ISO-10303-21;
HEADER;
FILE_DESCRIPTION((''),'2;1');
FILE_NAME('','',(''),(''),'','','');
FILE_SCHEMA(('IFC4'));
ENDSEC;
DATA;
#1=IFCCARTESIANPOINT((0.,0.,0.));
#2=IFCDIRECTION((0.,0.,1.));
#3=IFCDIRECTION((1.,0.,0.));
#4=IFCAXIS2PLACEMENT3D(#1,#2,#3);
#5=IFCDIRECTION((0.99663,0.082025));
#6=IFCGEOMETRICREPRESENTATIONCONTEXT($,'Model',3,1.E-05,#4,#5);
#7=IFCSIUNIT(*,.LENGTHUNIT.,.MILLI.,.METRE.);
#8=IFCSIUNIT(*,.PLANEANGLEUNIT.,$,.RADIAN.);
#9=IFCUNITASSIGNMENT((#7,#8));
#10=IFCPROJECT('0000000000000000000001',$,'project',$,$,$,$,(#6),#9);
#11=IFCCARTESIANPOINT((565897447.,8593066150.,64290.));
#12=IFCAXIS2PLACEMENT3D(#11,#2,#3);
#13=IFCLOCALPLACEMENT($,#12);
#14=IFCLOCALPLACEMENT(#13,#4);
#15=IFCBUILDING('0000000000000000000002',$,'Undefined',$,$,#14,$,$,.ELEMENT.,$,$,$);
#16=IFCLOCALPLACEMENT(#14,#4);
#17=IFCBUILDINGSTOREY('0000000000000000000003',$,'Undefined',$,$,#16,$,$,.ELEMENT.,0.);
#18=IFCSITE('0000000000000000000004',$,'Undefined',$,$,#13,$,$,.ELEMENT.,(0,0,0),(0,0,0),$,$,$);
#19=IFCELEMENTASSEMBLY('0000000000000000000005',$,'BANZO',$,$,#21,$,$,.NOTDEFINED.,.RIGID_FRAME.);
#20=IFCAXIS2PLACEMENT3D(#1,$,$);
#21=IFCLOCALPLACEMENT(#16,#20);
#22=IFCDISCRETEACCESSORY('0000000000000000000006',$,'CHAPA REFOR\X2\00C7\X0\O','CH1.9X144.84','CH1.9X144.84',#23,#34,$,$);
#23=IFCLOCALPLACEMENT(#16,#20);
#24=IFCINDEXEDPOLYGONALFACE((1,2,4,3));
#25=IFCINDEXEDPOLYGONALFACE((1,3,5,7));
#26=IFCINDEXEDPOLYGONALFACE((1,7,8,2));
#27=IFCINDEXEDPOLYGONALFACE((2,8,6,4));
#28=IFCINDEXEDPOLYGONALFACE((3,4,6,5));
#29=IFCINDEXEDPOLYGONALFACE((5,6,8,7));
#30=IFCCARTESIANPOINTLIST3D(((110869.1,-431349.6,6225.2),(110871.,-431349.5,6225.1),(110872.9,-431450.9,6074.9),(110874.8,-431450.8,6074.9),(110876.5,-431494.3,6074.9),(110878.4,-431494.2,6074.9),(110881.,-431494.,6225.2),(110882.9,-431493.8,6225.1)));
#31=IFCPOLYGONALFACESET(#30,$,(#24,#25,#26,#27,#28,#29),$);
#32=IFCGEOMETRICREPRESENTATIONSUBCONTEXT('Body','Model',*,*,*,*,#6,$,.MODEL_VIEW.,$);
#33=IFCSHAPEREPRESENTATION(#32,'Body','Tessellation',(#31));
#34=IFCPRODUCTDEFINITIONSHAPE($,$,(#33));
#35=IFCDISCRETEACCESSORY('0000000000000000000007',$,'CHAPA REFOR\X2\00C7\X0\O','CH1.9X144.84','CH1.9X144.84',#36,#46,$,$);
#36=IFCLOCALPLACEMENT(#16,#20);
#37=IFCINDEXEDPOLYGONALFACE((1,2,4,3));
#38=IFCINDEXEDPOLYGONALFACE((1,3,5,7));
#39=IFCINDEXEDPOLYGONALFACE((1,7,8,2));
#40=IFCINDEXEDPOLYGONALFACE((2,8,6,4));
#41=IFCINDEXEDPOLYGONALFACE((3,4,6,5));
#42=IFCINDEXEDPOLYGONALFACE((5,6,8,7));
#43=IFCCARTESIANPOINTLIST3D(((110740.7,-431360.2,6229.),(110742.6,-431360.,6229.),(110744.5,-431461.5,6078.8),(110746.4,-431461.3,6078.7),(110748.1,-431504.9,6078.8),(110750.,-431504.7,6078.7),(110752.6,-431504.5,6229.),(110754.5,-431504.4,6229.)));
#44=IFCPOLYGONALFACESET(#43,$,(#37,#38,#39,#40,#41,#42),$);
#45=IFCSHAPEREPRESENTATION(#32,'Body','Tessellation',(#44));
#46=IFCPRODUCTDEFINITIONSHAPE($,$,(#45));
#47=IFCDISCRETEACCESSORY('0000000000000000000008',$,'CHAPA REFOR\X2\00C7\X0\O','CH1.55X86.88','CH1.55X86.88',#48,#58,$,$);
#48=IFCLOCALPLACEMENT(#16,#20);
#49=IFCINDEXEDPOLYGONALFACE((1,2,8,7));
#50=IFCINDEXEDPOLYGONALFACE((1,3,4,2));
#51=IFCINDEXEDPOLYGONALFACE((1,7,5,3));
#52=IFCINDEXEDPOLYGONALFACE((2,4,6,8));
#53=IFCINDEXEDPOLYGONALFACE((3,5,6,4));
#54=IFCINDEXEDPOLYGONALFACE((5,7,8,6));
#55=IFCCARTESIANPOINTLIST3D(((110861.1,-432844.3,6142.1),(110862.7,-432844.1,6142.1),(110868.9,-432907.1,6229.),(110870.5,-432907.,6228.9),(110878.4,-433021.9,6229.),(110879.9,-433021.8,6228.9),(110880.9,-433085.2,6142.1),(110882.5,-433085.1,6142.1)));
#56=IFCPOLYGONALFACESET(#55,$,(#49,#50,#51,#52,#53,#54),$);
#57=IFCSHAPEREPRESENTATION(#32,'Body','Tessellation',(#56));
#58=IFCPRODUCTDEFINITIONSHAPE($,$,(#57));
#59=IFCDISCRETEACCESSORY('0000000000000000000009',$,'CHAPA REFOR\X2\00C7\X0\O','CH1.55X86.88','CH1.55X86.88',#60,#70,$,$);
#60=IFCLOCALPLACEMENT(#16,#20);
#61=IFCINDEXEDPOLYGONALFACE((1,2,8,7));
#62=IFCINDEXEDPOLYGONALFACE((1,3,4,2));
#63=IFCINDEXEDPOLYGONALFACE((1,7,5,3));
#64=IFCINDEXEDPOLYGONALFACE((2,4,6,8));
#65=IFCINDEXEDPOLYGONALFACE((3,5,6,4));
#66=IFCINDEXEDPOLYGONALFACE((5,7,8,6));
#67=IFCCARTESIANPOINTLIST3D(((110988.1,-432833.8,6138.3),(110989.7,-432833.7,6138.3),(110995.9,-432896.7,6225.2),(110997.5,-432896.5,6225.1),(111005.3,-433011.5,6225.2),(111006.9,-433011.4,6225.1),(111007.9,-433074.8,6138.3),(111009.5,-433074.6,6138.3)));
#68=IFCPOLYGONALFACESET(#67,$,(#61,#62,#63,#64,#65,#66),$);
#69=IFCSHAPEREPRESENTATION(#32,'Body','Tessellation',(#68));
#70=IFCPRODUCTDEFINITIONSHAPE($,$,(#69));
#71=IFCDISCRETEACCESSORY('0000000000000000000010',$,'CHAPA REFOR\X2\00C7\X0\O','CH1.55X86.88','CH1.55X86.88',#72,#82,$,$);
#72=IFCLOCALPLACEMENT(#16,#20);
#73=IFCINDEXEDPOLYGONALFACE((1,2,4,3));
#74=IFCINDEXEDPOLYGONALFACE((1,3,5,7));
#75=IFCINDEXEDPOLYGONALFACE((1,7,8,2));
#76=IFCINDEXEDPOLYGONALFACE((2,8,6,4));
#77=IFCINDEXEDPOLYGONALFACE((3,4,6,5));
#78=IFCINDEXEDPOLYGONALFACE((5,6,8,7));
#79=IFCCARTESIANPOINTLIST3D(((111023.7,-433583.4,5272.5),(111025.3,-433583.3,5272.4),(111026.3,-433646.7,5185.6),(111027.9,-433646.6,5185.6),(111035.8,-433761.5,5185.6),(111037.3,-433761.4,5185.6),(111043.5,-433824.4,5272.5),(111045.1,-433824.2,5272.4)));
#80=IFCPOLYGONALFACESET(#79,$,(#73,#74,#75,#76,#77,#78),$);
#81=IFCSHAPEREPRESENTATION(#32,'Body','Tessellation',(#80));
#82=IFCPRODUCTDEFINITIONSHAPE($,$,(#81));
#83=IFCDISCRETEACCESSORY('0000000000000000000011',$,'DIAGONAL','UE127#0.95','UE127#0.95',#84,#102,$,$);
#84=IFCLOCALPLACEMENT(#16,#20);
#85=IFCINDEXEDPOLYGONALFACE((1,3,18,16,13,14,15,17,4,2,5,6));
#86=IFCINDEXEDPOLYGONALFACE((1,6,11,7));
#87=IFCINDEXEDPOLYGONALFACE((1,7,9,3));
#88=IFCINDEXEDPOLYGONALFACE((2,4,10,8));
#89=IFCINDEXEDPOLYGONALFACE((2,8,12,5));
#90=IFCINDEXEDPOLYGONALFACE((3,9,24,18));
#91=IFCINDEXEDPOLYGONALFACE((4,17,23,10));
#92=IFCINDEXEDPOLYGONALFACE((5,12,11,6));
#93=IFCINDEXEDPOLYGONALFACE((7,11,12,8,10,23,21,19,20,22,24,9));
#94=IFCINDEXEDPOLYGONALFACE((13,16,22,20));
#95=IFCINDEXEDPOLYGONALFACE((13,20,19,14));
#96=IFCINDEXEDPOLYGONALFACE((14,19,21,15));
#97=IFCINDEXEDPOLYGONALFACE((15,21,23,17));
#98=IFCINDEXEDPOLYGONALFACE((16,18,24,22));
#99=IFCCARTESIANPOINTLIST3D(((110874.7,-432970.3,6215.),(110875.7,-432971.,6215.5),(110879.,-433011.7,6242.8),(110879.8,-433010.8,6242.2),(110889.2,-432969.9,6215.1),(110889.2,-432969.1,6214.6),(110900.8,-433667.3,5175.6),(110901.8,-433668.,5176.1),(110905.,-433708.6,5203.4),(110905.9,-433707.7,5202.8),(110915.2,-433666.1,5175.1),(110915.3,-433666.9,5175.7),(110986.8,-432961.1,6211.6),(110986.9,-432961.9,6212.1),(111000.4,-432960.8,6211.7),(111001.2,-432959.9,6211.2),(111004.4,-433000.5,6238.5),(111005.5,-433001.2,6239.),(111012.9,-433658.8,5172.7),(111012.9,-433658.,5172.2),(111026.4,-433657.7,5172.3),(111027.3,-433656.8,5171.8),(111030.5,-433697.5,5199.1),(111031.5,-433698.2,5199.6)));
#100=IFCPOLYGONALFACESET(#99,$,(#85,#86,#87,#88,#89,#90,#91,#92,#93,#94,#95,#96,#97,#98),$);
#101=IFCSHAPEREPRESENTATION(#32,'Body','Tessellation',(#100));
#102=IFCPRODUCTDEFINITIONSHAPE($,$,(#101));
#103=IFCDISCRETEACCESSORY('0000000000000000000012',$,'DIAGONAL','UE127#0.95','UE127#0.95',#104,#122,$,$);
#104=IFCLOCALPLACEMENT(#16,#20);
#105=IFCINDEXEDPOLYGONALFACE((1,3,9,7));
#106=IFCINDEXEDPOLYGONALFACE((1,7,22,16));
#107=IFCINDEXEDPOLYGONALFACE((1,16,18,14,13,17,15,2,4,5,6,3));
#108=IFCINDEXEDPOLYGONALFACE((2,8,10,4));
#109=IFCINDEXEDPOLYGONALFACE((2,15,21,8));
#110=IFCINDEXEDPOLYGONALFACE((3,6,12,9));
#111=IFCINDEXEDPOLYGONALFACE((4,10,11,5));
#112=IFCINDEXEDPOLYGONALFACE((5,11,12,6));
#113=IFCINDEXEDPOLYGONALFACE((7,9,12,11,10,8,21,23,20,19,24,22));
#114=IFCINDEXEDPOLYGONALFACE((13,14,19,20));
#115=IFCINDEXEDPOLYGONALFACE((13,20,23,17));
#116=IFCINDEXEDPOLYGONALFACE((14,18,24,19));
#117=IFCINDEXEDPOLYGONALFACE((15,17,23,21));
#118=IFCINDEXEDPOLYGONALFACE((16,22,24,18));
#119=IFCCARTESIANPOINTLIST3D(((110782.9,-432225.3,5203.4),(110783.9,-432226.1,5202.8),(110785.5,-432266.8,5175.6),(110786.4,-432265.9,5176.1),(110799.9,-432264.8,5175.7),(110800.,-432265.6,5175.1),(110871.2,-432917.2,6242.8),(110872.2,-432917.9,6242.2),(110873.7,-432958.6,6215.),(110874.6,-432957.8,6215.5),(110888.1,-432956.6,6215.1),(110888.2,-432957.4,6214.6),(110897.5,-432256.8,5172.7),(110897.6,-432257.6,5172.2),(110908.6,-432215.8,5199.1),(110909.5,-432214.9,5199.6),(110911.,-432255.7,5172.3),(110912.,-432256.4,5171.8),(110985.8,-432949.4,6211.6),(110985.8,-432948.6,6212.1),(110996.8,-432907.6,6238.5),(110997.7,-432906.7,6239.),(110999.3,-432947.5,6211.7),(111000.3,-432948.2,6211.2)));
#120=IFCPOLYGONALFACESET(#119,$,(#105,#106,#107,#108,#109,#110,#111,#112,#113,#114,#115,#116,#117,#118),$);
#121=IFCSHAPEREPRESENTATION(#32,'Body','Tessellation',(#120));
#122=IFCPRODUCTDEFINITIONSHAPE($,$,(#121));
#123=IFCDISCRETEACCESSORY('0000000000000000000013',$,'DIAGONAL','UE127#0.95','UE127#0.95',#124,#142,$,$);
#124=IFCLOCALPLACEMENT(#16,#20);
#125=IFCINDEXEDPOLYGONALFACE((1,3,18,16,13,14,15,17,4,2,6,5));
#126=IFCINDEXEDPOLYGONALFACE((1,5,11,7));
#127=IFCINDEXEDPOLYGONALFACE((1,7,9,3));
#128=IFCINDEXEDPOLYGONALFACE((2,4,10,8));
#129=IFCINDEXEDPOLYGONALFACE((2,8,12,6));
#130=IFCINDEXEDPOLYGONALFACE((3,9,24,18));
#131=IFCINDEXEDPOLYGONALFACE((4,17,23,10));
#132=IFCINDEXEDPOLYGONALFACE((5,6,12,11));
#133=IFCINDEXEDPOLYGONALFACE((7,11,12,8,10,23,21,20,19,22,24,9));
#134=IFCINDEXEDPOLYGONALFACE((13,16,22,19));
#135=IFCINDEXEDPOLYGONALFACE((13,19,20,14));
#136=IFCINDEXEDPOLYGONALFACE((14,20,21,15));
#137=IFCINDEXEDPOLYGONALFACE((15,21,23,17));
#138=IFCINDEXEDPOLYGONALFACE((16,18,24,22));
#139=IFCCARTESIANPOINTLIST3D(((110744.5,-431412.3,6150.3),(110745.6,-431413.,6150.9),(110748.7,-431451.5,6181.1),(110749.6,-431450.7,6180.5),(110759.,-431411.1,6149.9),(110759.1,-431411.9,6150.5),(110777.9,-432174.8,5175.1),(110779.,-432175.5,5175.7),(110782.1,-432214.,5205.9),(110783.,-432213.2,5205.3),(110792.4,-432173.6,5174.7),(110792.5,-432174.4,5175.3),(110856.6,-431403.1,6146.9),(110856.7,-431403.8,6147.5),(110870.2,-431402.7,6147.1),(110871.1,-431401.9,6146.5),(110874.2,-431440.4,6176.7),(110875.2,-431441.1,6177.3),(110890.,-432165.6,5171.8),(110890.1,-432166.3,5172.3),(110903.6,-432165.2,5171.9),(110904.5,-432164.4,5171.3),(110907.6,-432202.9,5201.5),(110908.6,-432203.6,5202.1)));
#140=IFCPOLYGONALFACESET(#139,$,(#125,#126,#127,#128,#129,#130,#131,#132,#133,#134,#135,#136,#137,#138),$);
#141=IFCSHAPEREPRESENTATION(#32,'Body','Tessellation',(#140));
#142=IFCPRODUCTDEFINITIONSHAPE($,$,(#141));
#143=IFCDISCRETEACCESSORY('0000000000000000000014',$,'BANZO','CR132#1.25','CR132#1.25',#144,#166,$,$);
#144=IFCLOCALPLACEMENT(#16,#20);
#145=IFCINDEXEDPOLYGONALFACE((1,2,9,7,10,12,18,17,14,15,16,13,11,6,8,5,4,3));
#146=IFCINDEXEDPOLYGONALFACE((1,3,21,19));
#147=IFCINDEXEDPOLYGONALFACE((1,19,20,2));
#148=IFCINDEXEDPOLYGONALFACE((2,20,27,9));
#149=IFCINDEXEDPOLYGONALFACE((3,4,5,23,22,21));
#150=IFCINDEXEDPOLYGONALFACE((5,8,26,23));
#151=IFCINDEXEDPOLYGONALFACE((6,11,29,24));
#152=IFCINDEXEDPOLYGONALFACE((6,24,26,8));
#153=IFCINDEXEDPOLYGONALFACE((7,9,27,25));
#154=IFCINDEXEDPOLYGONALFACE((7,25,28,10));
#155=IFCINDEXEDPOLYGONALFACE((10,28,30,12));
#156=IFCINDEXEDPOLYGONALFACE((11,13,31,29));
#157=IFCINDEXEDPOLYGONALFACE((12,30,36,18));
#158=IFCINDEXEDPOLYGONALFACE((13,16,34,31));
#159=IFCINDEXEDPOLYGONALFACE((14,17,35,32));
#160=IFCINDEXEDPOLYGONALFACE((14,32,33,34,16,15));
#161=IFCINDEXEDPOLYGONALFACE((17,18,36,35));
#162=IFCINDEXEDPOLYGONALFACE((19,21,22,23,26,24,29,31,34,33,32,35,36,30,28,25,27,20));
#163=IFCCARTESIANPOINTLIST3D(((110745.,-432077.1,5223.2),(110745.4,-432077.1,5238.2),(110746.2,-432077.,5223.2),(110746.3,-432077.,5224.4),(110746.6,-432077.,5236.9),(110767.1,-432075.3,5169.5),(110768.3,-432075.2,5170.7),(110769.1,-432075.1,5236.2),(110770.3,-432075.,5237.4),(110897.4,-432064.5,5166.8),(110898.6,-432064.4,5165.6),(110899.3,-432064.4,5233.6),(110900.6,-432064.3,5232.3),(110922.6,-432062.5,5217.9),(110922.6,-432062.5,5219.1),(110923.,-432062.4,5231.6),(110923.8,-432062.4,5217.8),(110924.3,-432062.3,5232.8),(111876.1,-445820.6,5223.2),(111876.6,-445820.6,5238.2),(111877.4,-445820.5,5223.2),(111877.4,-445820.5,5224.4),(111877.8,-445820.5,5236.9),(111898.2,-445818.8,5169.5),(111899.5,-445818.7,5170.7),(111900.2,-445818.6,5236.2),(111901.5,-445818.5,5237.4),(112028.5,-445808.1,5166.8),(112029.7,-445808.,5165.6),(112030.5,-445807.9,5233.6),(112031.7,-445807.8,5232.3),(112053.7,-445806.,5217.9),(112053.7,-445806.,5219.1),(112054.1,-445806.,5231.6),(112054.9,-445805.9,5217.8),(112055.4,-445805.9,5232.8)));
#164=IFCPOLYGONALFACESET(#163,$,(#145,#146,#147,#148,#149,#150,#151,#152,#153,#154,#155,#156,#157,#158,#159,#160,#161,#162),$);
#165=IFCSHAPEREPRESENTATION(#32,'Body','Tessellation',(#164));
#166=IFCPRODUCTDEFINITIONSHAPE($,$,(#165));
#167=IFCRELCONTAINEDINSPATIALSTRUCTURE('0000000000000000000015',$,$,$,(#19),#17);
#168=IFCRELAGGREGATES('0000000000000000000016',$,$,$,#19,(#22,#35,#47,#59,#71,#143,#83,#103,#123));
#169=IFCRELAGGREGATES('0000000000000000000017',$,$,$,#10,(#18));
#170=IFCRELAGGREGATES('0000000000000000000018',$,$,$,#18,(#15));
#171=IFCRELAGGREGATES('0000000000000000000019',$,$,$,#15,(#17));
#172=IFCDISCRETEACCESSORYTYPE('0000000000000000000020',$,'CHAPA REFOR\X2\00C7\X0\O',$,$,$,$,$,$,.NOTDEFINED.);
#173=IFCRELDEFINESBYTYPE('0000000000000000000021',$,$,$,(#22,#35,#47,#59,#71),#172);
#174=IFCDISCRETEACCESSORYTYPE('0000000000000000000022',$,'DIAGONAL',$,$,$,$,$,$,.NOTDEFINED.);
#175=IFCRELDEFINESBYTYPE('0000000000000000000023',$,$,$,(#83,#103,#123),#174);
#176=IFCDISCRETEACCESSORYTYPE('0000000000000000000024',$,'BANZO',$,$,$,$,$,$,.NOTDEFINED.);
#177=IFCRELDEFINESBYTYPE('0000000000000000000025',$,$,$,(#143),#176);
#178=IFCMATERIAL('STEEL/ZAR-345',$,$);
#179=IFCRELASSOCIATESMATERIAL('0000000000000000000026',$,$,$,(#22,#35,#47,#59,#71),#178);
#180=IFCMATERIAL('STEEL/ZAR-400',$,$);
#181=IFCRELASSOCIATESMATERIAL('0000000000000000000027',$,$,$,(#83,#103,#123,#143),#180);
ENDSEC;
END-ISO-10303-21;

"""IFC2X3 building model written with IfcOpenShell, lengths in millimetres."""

from ifc_helpers import new_model, si_unit, direction, frame, frame_2d, origin_with_axes, place, context, subcontext, project, spatial, polyline, c_section, outline, extrude, material, type_object, element, aggregate, save


model = new_model("IFC2X3")

# Units and contexts
model_context = context("Model", 3, precision=1e-05, world=origin_with_axes(), true_north=direction((0.99663, 0.082025)))
body_context = subcontext(model_context, "Body", "Model", "MODEL_VIEW")
ifc_project = project(units=[si_unit("LENGTHUNIT", "METRE", prefix="MILLI"), si_unit("PLANEANGLEUNIT", "RADIAN")], contexts=[model_context])

# Site, building, storey
site_placement = place(None, frame((565897447.0, 8593066150.0, 64290.0), z_axis=(0.0, 0.0, 1.0), x_axis=(1.0, 0.0, 0.0)))
site = spatial("IfcSite", under=ifc_project, at=site_placement, Name="Undefined", CompositionType="ELEMENT", RefLatitude=(0, 0, 0), RefLongitude=(0, 0, 0))
building_placement = place(site_placement, origin_with_axes())
building = spatial("IfcBuilding", under=site, at=building_placement, Name="Undefined", CompositionType="ELEMENT")
storey_placement = place(building_placement, origin_with_axes())
storey = spatial("IfcBuildingStorey", under=building, at=storey_placement, Name="Undefined", CompositionType="ELEMENT", Elevation=0.0)

# Shared definitions
ifc_material_1 = material(Name="STEEL/ZAR-400")

# Element assembly, discrete accessories
assembly_1_placement = place(storey_placement, origin_with_axes())
assembly_1 = element("IfcElementAssembly", 1, at=assembly_1_placement, inside=storey, Name="BANZO", AssemblyPlace="NOTDEFINED", PredefinedType="RIGID_FRAME")
ifc_material_2 = material(Name="STEEL/ZAR-345")
discrete_accessory_type_1 = type_object("IfcDiscreteAccessoryType", Name="CHAPA REFORÇO")
discrete_accessory_1_placement = place(assembly_1_placement, frame((110881.9, -431493.9, 6225.1), z_axis=(-0.996182, -0.081989, 0.029987), x_axis=(-0.082025, 0.99663, 0.0)))
discrete_accessory_1 = element("IfcDiscreteAccessory", 2, at=discrete_accessory_1_placement, type_object=discrete_accessory_type_1, material=ifc_material_2, Name="CHAPA REFORÇO", Description="CH1.9X144.84", ObjectType="CH1.9X144.84", context=body_context, shape_type="SweptSolid", body=[
    extrude(outline(polyline([(0.0, 0.0), (144.8, 0.0), (43.5, 150.3), (0.0, 150.3), (0.0, 0.0)])), frame((0.0, 0.0, -0.9), z_axis=(0.0, 0.0, 1.0), x_axis=(1.0, 0.0, 0.0)), (0.0, 0.0, 1.0), 1.9),
])
discrete_accessory_2_placement = place(assembly_1_placement, frame((110753.5, -431504.5, 6229.0), z_axis=(-0.996182, -0.081989, 0.029987), x_axis=(-0.082025, 0.99663, 0.0)))
discrete_accessory_2 = element("IfcDiscreteAccessory", 3, at=discrete_accessory_2_placement, type_object=discrete_accessory_type_1, material=ifc_material_2, Name="CHAPA REFORÇO", Description="CH1.9X144.84", ObjectType="CH1.9X144.84", context=body_context, shape_type="SweptSolid", body=[
    extrude(outline(polyline([(0.0, 0.0), (144.8, 0.0), (43.5, 150.3), (0.0, 150.3), (0.0, 0.0)])), frame((0.0, 0.0, -0.9), z_axis=(0.0, 0.0, 1.0), x_axis=(1.0, 0.0, 0.0)), (0.0, 0.0, 1.0), 1.9),
])
discrete_accessory_3_placement = place(assembly_1_placement, frame((110861.9, -432844.2, 6142.1), z_axis=(-0.996182, -0.081989, 0.029987), x_axis=(0.082025, -0.99663, 0.0)))
discrete_accessory_3 = element("IfcDiscreteAccessory", 4, at=discrete_accessory_3_placement, type_object=discrete_accessory_type_1, material=ifc_material_2, Name="CHAPA REFORÇO", Description="CH1.55X86.88", ObjectType="CH1.55X86.88", context=body_context, shape_type="SweptSolid", body=[
    extrude(outline(polyline([(0.0, 0.0), (241.7, 0.0), (178.5, 86.9), (63.3, 86.9), (0.0, 0.0)])), frame((0.0, 0.0, -0.8), z_axis=(0.0, 0.0, 1.0), x_axis=(1.0, 0.0, 0.0)), (0.0, 0.0, 1.0), 1.6),
])
discrete_accessory_4_placement = place(assembly_1_placement, frame((110988.9, -432833.8, 6138.3), z_axis=(-0.996182, -0.081989, 0.029987), x_axis=(0.082025, -0.99663, 0.0)))
discrete_accessory_4 = element("IfcDiscreteAccessory", 5, at=discrete_accessory_4_placement, type_object=discrete_accessory_type_1, material=ifc_material_2, Name="CHAPA REFORÇO", Description="CH1.55X86.88", ObjectType="CH1.55X86.88", context=body_context, shape_type="SweptSolid", body=[
    extrude(outline(polyline([(0.0, 0.0), (241.7, 0.0), (178.5, 86.9), (63.3, 86.9), (0.0, 0.0)])), frame((0.0, 0.0, -0.8), z_axis=(0.0, 0.0, 1.0), x_axis=(1.0, 0.0, 0.0)), (0.0, 0.0, 1.0), 1.6),
])
discrete_accessory_5_placement = place(assembly_1_placement, frame((111044.3, -433824.3, 5272.5), z_axis=(-0.996182, -0.081989, 0.029987), x_axis=(-0.082025, 0.99663, 0.0)))
discrete_accessory_5 = element("IfcDiscreteAccessory", 6, at=discrete_accessory_5_placement, type_object=discrete_accessory_type_1, material=ifc_material_2, Name="CHAPA REFORÇO", Description="CH1.55X86.88", ObjectType="CH1.55X86.88", context=body_context, shape_type="SweptSolid", body=[
    extrude(outline(polyline([(0.0, 0.0), (241.7, 0.0), (178.5, 86.9), (63.3, 86.9), (0.0, 0.0)])), frame((0.0, 0.0, -0.8), z_axis=(0.0, 0.0, 1.0), x_axis=(1.0, 0.0, 0.0)), (0.0, 0.0, 1.0), 1.6),
])
discrete_accessory_type_2 = type_object("IfcDiscreteAccessoryType", Name="DIAGONAL")
discrete_accessory_6_placement = place(assembly_1_placement, frame((110966.2, -433682.7, 5187.6), z_axis=(0.996182, 0.081989, -0.029987), x_axis=(-0.020829, 0.556784, 0.830396)))
discrete_accessory_6 = element("IfcDiscreteAccessory", 7, at=discrete_accessory_6_placement, type_object=discrete_accessory_type_2, material=ifc_material_1, Name="DIAGONAL", Description="UE127#0.95", ObjectType="UE127#0.95", context=body_context, shape_type="SweptSolid", body=[
    extrude(c_section(Depth=127.0, Width=50.0, WallThickness=0.9, Girth=14.5, at=frame_2d((0.0, 0.0), x_axis=(1.0, 0.0))), frame((1251.7, 0.0, 0.0), z_axis=(-1.0, 0.0, 0.0), x_axis=(0.0, -1.0, 0.0)), (0.0, 0.0, 1.0), 1251.7),
])
discrete_accessory_7_placement = place(assembly_1_placement, frame((110935.7, -432932.7, 6227.0), z_axis=(0.996182, 0.081989, -0.029987), x_axis=(-0.070485, 0.552697, -0.830396)))
discrete_accessory_7 = element("IfcDiscreteAccessory", 8, at=discrete_accessory_7_placement, type_object=discrete_accessory_type_2, material=ifc_material_1, Name="DIAGONAL", Description="UE127#0.95", ObjectType="UE127#0.95", context=body_context, shape_type="SweptSolid", body=[
    extrude(c_section(Depth=127.0, Width=50.0, WallThickness=0.9, Girth=14.5, at=frame_2d((0.0, 0.0), x_axis=(1.0, 0.0))), frame((1251.7, 0.0, 0.0), z_axis=(-1.0, 0.0, 0.0), x_axis=(0.0, -1.0, 0.0)), (0.0, 0.0, 1.0), 1251.7),
])
discrete_accessory_8_placement = place(assembly_1_placement, frame((110843.3, -432189.2, 5188.6), z_axis=(0.996182, 0.081989, -0.029987), x_axis=(-0.026972, 0.615729, 0.787496)))
discrete_accessory_8 = element("IfcDiscreteAccessory", 9, at=discrete_accessory_8_placement, type_object=discrete_accessory_type_2, material=ifc_material_1, Name="DIAGONAL", Description="UE127#0.95", ObjectType="UE127#0.95", context=body_context, shape_type="SweptSolid", body=[
    extrude(c_section(Depth=127.0, Width=50.0, WallThickness=0.9, Girth=14.5, at=frame_2d((0.0, 0.0), x_axis=(1.0, 0.0))), frame((1238.3, 0.0, 0.0), z_axis=(-1.0, 0.0, 0.0), x_axis=(0.0, -1.0, 0.0)), (0.0, 0.0, 1.0), 1238.3),
])
discrete_accessory_type_3 = type_object("IfcDiscreteAccessoryType", Name="BANZO")
discrete_accessory_9_placement = place(assembly_1_placement, frame((110833.8, -432069.8, 5201.5), z_axis=(-0.029886, -0.00246, -0.99955), x_axis=(0.082025, -0.99663, 0.0)))
discrete_accessory_9 = element("IfcDiscreteAccessory", 10, at=discrete_accessory_9_placement, type_object=discrete_accessory_type_3, material=ifc_material_1, Name="BANZO", Description="CR132#1.25", ObjectType="CR132#1.25", context=body_context, shape_type="SweptSolid", body=[
    extrude(outline(polyline([(-64.7, 32.7), (-64.7, -34.0), (-89.7, -34.0), (-89.7, -19.0), (-88.5, -19.0), (-88.5, -20.3), (-88.5, -32.8), (-66.0, -32.8), (-66.0, 34.0), (66.0, 34.0), (66.0, -32.7), (88.5, -32.7), (88.5, -20.2), (88.5, -19.0), (89.7, -19.0), (89.7, -34.0), (64.7, -34.0), (64.7, 32.8), (-64.7, 32.7)])), frame((13790.0, 0.0, 0.0), z_axis=(-1.0, 0.0, 0.0), x_axis=(0.0, -1.0, 0.0)), (0.0, 0.0, 1.0), 13790.0),
])
aggregate(assembly_1, [discrete_accessory_1, discrete_accessory_2, discrete_accessory_3, discrete_accessory_4, discrete_accessory_5, discrete_accessory_9, discrete_accessory_6, discrete_accessory_7, discrete_accessory_8])

save(model, "model.ifc")
